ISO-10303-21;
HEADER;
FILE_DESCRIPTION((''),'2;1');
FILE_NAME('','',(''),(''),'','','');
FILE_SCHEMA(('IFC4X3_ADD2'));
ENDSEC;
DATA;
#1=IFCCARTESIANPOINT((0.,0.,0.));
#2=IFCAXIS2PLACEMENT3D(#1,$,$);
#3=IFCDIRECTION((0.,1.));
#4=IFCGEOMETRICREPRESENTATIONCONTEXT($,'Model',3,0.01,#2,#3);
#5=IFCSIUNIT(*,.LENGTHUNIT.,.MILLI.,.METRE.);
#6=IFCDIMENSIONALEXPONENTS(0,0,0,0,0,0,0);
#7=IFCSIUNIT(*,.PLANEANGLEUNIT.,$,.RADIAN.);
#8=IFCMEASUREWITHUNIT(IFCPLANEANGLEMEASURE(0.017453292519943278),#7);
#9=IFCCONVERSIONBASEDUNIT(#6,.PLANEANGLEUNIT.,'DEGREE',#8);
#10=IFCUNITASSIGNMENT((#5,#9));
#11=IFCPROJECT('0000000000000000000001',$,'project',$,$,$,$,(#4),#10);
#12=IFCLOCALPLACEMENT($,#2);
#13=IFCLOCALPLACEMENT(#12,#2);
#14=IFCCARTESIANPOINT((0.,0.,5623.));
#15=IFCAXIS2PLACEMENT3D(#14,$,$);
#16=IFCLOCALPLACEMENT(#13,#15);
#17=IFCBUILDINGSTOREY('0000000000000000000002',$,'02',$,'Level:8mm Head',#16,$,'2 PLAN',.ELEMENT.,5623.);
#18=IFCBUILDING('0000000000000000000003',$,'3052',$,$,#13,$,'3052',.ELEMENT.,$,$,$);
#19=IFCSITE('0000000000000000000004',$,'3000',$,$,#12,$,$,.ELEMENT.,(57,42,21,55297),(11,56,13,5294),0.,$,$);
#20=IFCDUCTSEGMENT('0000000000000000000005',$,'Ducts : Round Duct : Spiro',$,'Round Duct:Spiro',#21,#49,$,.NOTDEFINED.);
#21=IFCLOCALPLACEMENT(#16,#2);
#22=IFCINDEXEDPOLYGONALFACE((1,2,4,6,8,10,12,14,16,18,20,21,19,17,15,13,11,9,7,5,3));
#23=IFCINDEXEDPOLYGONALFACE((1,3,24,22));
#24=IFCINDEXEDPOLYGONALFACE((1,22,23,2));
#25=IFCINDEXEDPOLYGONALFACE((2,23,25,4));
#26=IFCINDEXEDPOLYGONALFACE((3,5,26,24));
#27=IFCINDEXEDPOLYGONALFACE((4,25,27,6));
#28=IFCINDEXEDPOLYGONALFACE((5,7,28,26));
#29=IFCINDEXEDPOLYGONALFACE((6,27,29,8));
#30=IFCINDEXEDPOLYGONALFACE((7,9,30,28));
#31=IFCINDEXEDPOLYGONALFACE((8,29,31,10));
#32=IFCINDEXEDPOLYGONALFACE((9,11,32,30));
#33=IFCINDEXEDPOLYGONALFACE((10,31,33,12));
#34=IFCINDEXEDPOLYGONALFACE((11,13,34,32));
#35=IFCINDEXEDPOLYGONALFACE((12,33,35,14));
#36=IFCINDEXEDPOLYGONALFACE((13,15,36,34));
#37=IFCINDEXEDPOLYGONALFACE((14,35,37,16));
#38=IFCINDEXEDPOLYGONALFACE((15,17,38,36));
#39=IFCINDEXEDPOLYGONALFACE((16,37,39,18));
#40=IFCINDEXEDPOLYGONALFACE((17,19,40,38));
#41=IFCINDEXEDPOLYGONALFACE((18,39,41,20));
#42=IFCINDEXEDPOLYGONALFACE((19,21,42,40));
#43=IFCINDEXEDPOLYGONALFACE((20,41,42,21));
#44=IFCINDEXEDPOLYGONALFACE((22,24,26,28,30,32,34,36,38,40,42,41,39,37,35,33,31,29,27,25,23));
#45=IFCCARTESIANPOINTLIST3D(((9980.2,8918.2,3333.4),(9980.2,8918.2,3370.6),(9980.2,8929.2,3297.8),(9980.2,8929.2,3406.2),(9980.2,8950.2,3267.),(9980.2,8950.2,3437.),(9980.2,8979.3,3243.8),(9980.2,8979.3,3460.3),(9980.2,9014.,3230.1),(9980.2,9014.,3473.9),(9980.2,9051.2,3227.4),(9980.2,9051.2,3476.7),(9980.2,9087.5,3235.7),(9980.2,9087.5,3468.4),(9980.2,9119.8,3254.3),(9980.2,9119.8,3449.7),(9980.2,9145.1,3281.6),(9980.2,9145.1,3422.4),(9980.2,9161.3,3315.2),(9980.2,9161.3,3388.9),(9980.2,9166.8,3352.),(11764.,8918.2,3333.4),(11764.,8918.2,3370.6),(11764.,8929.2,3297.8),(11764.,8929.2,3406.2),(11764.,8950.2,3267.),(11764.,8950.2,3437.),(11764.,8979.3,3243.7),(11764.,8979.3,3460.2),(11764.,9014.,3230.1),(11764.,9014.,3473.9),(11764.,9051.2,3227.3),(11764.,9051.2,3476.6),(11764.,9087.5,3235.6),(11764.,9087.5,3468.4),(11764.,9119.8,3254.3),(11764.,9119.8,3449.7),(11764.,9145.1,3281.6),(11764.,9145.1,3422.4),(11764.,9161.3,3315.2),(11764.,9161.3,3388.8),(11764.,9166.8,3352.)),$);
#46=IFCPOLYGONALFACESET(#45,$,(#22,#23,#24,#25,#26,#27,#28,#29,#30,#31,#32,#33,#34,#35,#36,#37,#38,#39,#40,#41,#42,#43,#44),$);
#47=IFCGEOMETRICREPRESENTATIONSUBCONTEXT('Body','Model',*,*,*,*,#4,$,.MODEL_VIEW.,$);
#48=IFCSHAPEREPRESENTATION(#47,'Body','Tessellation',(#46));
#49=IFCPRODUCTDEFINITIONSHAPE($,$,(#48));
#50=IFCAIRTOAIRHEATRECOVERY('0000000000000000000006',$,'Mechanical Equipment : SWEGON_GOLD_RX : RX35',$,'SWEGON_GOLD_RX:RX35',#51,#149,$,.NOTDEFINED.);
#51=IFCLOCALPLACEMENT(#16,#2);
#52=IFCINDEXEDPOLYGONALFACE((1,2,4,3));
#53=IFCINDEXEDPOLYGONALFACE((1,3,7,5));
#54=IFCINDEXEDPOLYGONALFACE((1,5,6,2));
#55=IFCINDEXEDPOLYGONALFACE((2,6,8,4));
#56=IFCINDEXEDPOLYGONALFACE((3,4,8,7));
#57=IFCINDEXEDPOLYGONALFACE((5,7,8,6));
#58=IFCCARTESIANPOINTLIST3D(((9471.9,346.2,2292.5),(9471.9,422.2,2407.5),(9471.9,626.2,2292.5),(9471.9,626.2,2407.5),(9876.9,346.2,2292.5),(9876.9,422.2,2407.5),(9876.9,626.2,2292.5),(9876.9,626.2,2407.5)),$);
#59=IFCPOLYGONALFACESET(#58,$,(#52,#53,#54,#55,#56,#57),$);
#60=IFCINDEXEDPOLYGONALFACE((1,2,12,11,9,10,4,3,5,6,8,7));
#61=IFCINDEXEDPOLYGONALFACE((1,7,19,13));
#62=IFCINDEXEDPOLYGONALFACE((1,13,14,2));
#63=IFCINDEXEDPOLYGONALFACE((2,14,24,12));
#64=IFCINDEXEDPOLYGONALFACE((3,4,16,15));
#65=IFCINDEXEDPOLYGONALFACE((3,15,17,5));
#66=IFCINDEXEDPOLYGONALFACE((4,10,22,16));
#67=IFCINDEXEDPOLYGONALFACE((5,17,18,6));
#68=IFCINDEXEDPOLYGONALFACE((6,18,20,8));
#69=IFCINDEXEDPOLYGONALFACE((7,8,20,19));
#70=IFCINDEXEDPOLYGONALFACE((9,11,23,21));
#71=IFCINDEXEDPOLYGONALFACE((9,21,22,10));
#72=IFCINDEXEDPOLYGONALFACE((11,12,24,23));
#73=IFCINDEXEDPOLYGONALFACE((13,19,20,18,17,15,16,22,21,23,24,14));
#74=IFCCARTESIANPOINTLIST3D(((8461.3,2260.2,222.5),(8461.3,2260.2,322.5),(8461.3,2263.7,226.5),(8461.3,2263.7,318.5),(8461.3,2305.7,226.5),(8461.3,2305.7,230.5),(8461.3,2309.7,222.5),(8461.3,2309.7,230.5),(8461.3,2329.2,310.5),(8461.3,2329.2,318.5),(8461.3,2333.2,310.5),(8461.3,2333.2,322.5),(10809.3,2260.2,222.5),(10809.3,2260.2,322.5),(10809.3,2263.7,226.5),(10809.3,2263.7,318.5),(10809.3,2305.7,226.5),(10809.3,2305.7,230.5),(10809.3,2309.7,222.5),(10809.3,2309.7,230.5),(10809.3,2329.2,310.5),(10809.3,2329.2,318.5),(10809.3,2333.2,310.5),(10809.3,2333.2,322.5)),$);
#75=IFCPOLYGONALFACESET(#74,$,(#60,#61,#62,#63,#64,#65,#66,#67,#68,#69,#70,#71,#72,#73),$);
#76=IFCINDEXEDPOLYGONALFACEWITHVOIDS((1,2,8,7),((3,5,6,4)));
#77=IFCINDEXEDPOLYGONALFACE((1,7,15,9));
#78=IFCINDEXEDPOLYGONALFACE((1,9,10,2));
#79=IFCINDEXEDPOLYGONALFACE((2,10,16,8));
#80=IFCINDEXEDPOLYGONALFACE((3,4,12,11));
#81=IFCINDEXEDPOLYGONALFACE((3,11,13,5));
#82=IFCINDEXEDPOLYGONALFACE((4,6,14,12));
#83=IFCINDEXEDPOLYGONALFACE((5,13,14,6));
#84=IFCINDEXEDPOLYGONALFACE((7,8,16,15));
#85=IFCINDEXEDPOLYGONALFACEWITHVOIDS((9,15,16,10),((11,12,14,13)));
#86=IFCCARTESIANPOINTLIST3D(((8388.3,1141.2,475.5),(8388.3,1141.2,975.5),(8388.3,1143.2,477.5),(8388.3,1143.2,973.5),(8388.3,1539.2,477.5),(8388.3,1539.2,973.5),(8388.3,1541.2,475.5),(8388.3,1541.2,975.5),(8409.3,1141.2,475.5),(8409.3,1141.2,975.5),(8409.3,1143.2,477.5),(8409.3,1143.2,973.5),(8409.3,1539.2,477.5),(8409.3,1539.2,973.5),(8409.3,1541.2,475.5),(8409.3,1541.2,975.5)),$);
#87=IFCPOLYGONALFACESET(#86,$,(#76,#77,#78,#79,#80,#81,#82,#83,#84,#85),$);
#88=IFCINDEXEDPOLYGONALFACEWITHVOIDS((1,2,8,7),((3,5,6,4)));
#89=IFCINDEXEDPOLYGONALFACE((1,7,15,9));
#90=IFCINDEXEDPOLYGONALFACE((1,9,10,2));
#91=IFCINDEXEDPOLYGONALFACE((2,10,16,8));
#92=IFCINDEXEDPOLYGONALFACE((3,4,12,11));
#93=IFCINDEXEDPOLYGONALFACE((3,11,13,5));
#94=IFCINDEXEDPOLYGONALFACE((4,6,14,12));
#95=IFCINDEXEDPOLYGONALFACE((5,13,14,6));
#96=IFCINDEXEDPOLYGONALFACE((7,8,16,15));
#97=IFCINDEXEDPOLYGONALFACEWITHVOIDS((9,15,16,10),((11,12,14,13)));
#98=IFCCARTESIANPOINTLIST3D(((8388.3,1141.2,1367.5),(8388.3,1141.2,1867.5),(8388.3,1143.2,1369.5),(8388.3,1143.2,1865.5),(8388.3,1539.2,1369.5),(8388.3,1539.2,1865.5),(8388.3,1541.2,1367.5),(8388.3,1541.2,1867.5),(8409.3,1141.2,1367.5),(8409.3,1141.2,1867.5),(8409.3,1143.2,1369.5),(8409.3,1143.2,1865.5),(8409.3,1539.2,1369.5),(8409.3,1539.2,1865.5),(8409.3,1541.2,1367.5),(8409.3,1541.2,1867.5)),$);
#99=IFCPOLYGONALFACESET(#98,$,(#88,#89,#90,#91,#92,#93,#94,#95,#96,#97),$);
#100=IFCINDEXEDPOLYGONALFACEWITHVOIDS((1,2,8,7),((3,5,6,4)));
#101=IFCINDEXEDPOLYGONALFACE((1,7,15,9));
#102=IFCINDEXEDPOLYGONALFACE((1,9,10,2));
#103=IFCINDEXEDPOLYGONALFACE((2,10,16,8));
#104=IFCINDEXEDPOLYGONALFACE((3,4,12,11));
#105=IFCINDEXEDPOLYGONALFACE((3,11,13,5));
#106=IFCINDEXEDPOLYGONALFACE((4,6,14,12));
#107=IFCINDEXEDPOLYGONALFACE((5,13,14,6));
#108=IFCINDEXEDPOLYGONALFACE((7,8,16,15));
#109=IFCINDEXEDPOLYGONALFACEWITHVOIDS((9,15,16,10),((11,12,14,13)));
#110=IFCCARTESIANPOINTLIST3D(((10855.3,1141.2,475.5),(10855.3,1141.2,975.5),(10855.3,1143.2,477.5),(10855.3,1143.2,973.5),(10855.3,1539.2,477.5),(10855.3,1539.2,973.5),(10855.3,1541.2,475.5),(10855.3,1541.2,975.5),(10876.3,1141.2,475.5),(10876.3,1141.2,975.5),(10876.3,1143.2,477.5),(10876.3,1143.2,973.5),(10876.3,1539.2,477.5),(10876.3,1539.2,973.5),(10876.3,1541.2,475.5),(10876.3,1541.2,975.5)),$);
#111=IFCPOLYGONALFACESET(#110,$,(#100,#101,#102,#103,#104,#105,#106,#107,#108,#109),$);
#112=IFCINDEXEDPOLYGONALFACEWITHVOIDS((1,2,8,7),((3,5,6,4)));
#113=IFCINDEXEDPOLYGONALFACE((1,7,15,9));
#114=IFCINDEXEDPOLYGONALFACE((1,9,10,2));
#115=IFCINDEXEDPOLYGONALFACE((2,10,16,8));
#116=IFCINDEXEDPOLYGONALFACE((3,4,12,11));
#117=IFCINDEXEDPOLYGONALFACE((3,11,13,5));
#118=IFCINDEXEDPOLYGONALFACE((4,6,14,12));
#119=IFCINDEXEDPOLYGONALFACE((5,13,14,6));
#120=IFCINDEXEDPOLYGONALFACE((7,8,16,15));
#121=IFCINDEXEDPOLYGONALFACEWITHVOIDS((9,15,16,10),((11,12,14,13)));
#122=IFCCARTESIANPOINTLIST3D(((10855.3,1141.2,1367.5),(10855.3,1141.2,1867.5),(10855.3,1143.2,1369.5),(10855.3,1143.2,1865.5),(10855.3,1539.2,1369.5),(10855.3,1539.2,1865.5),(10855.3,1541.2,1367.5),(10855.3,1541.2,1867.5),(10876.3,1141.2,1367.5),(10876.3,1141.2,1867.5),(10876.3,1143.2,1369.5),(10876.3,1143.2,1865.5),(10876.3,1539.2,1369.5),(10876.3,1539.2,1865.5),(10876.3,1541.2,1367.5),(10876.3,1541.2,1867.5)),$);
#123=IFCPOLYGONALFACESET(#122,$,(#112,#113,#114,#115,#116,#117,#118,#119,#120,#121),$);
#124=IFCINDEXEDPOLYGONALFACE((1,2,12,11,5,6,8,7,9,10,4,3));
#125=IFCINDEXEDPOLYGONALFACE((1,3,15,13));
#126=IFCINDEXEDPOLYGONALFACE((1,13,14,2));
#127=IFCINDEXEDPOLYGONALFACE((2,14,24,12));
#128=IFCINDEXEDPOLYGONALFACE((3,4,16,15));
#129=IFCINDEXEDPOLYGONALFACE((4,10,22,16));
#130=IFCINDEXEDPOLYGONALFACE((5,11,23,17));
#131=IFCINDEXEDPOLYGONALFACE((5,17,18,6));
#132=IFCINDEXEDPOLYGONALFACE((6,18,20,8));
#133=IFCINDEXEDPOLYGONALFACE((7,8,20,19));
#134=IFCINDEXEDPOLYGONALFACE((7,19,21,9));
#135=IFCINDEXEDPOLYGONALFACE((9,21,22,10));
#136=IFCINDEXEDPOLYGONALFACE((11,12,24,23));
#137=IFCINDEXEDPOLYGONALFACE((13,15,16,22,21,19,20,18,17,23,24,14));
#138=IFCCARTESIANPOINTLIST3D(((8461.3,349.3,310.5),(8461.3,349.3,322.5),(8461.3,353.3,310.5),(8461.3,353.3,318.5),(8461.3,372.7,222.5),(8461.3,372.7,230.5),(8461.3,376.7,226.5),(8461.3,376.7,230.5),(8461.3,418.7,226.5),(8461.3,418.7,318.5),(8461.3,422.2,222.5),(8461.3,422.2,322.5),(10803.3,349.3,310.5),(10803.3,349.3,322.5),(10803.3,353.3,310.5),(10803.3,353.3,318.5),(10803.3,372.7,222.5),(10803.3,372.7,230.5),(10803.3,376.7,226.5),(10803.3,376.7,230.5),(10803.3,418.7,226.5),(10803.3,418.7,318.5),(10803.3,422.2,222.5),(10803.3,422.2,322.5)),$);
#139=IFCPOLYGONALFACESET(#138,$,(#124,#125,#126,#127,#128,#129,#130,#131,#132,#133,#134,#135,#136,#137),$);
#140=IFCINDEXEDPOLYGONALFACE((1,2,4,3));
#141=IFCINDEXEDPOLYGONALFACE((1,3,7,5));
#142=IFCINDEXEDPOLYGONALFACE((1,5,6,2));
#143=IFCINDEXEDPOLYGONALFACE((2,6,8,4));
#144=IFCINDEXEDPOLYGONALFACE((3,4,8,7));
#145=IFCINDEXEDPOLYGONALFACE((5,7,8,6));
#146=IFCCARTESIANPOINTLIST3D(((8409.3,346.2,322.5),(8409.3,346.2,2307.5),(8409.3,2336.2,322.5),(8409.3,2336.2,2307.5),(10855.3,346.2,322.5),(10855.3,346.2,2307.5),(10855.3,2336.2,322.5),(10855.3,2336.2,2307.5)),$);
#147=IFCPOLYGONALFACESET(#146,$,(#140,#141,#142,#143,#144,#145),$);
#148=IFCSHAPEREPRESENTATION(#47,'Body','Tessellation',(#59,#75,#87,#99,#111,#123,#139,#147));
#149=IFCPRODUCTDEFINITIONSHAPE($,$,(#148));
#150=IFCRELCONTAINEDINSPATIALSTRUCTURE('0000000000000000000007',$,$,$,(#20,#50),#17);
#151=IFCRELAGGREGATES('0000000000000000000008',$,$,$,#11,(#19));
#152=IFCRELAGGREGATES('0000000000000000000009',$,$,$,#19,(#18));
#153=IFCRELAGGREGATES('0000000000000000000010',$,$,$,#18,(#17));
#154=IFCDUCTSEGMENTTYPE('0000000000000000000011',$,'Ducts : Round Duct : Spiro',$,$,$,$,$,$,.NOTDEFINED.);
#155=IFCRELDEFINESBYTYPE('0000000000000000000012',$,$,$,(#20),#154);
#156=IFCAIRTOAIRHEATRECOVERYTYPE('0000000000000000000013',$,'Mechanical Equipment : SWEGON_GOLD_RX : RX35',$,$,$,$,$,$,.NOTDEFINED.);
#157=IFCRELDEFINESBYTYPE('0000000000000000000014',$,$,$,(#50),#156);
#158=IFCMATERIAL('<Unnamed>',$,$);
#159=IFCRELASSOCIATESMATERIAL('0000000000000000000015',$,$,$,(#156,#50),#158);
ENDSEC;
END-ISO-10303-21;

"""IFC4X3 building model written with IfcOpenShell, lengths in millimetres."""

from ifc_helpers import new_model, entity, si_unit, converted_unit, direction, frame, origin, origin_2d_with_axis, place, context, subcontext, project, spatial, polyline, rectangle, circle, outline, extrude, source, transform, mapped, material, type_object, type_shapes, element, save


model = new_model("IFC4X3")

# Units and contexts
model_context = context("Model", 3, precision=0.01, world=origin(), true_north=direction((0.0, 1.0)))
body_context = subcontext(model_context, "Body", "Model", "MODEL_VIEW")
ifc_project = project(units=[si_unit("LENGTHUNIT", "METRE", prefix="MILLI"), converted_unit("PLANEANGLEUNIT", "DEGREE", entity("IfcPlaneAngleMeasure", 0.017453292519943278), si_unit("PLANEANGLEUNIT", "RADIAN"), dimensions=[0, 0, 0, 0, 0, 0, 0])], contexts=[model_context])

# Site, building, storey
site_placement = place(None, origin())
site = spatial("IfcSite", under=ifc_project, at=site_placement, Name="3000", CompositionType="ELEMENT", RefLatitude=(57, 42, 21, 55297), RefLongitude=(11, 56, 13, 5294), RefElevation=0.0)
building_placement = place(site_placement, origin())
building = spatial("IfcBuilding", under=site, at=building_placement, Name="3052", LongName="3052", CompositionType="ELEMENT")
storey_placement = place(building_placement, frame((0.0, 0.0, 5623.0)))
storey = spatial("IfcBuildingStorey", under=building, at=storey_placement, Name="02", ObjectType="Level:8mm Head", LongName="2 PLAN", CompositionType="ELEMENT", Elevation=5623.0)

# Duct segment
duct_segment_type = type_object("IfcDuctSegmentType", Name="Ducts : Round Duct : Spiro", PredefinedType="NOTDEFINED")
duct_segment_1_placement = place(storey_placement, frame((9980.2, 8915.2, 3478.6)))
element("IfcDuctSegment", 1, at=duct_segment_1_placement, inside=storey, type_object=duct_segment_type, Name="Ducts : Round Duct : Spiro", ObjectType="Round Duct:Spiro", PredefinedType="NOTDEFINED", context=body_context, shape_type="SweptSolid", body=[
    extrude(circle(Radius=125.0, at=origin_2d_with_axis()), frame((0.0, 126.6, -126.6), z_axis=(1.0, 0.0, -0.000008), x_axis=(0.0, 1.0, 0.0)), (0.0, 0.0, 1.0), 1783.9),
])

# Air to air heat recovery
ifc_material_1 = material(Name="<Unnamed>")
air_to_air_heat_recovery_type = type_object("IfcAirToAirHeatRecoveryType", Name="Mechanical Equipment : SWEGON_GOLD_RX : RX35", PredefinedType="NOTDEFINED", material=ifc_material_1)
shared_shape_1 = source(origin(), body_context, "Body", "SweptSolid", [
    extrude(outline(polyline([(-57.5, -121.0), (57.5, -121.0), (57.5, 83.0), (-57.5, 159.0), (-57.5, -121.0)])), frame((836.0, -1383.3, 2127.5), z_axis=(0.0, 1.0, 0.0), x_axis=(0.0, 0.0, 1.0)), (0.0, 0.0, 1.0), 405.0),
    extrude(outline(polyline([(-40.1, -49.3), (9.4, -49.3), (9.4, -41.3), (5.4, -41.3), (5.4, -45.3), (-36.6, -45.3), (-36.6, 46.7), (28.9, 46.7), (28.9, 38.7), (32.9, 38.7), (32.9, 50.7), (-40.1, 50.7), (-40.1, -49.3)])), frame((-959.1, -2394.0, 49.3), z_axis=(0.0, 1.0, 0.0), x_axis=(-1.0, 0.0, 0.0)), (0.0, 0.0, 1.0), 2348.0),
    extrude(outline(polyline([(-200.0, -250.0), (200.0, -250.0), (200.0, 250.0), (-200.0, 250.0), (-200.0, -250.0)]), holes=[polyline([(-198.0, -248.0), (-198.0, 248.0), (198.0, 248.0), (198.0, -248.0), (-198.0, -248.0)])]), frame((0.0, -2467.0, 503.0), z_axis=(0.0, 1.0, 0.0), x_axis=(1.0, 0.0, 0.0)), (0.0, 0.0, 1.0), 21.0),
    extrude(outline(polyline([(-200.0, -250.0), (200.0, -250.0), (200.0, 250.0), (-200.0, 250.0), (-200.0, -250.0)]), holes=[polyline([(-198.0, -248.0), (-198.0, 248.0), (198.0, 248.0), (198.0, -248.0), (-198.0, -248.0)])]), frame((0.0, -2467.0, 1395.0), z_axis=(0.0, 1.0, 0.0), x_axis=(1.0, 0.0, 0.0)), (0.0, 0.0, 1.0), 21.0),
    extrude(outline(polyline([(-200.0, -250.0), (200.0, -250.0), (200.0, 250.0), (-200.0, 250.0), (-200.0, -250.0)]), holes=[polyline([(-198.0, -248.0), (-198.0, 248.0), (198.0, 248.0), (198.0, -248.0), (-198.0, -248.0)])]), frame((0.0, 0.0, 503.0), z_axis=(0.0, 1.0, 0.0), x_axis=(1.0, 0.0, 0.0)), (0.0, 0.0, 1.0), 21.0),
    extrude(outline(polyline([(-200.0, -250.0), (200.0, -250.0), (200.0, 250.0), (-200.0, 250.0), (-200.0, -250.0)]), holes=[polyline([(-198.0, -248.0), (-198.0, 248.0), (198.0, 248.0), (198.0, -248.0), (-198.0, -248.0)])]), frame((0.0, 0.0, 1395.0), z_axis=(0.0, 1.0, 0.0), x_axis=(1.0, 0.0, 0.0)), (0.0, 0.0, 1.0), 21.0),
    extrude(outline(polyline([(-49.3, -40.1), (50.7, -40.1), (50.7, 32.9), (38.7, 32.9), (38.7, 28.9), (46.7, 28.9), (46.7, -36.6), (-45.3, -36.6), (-45.3, 5.4), (-41.3, 5.4), (-41.3, 9.4), (-49.3, 9.4), (-49.3, -40.1)])), frame((959.1, -2394.0, 49.3), z_axis=(0.0, 1.0, 0.0), x_axis=(0.0, 0.0, 1.0)), (0.0, 0.0, 1.0), 2342.0),
    extrude(rectangle(XDim=2446.0, YDim=1990.0, at=origin_2d_with_axis()), frame((0.0, -1223.0, 100.0), z_axis=(0.0, 0.0, 1.0), x_axis=(0.0, -1.0, 0.0)), (0.0, 0.0, 1.0), 1985.0),
])
type_shapes(air_to_air_heat_recovery_type, [shared_shape_1])
air_to_air_heat_recovery_placement = place(storey_placement, frame((10855.3, 1341.2, 222.5), z_axis=(0.0, 0.0, 1.0), x_axis=(0.0, -1.0, 0.0)))
element("IfcAirToAirHeatRecovery", 2, at=air_to_air_heat_recovery_placement, inside=storey, type_object=air_to_air_heat_recovery_type, material=ifc_material_1, Name="Mechanical Equipment : SWEGON_GOLD_RX : RX35", ObjectType="SWEGON_GOLD_RX:RX35", PredefinedType="NOTDEFINED", context=body_context, shape_type="MappedRepresentation", body=[
    mapped(shared_shape_1, transform((0.0, 0.0, 0.0), scale=1.0)),
])

save(model, "model.ifc")
